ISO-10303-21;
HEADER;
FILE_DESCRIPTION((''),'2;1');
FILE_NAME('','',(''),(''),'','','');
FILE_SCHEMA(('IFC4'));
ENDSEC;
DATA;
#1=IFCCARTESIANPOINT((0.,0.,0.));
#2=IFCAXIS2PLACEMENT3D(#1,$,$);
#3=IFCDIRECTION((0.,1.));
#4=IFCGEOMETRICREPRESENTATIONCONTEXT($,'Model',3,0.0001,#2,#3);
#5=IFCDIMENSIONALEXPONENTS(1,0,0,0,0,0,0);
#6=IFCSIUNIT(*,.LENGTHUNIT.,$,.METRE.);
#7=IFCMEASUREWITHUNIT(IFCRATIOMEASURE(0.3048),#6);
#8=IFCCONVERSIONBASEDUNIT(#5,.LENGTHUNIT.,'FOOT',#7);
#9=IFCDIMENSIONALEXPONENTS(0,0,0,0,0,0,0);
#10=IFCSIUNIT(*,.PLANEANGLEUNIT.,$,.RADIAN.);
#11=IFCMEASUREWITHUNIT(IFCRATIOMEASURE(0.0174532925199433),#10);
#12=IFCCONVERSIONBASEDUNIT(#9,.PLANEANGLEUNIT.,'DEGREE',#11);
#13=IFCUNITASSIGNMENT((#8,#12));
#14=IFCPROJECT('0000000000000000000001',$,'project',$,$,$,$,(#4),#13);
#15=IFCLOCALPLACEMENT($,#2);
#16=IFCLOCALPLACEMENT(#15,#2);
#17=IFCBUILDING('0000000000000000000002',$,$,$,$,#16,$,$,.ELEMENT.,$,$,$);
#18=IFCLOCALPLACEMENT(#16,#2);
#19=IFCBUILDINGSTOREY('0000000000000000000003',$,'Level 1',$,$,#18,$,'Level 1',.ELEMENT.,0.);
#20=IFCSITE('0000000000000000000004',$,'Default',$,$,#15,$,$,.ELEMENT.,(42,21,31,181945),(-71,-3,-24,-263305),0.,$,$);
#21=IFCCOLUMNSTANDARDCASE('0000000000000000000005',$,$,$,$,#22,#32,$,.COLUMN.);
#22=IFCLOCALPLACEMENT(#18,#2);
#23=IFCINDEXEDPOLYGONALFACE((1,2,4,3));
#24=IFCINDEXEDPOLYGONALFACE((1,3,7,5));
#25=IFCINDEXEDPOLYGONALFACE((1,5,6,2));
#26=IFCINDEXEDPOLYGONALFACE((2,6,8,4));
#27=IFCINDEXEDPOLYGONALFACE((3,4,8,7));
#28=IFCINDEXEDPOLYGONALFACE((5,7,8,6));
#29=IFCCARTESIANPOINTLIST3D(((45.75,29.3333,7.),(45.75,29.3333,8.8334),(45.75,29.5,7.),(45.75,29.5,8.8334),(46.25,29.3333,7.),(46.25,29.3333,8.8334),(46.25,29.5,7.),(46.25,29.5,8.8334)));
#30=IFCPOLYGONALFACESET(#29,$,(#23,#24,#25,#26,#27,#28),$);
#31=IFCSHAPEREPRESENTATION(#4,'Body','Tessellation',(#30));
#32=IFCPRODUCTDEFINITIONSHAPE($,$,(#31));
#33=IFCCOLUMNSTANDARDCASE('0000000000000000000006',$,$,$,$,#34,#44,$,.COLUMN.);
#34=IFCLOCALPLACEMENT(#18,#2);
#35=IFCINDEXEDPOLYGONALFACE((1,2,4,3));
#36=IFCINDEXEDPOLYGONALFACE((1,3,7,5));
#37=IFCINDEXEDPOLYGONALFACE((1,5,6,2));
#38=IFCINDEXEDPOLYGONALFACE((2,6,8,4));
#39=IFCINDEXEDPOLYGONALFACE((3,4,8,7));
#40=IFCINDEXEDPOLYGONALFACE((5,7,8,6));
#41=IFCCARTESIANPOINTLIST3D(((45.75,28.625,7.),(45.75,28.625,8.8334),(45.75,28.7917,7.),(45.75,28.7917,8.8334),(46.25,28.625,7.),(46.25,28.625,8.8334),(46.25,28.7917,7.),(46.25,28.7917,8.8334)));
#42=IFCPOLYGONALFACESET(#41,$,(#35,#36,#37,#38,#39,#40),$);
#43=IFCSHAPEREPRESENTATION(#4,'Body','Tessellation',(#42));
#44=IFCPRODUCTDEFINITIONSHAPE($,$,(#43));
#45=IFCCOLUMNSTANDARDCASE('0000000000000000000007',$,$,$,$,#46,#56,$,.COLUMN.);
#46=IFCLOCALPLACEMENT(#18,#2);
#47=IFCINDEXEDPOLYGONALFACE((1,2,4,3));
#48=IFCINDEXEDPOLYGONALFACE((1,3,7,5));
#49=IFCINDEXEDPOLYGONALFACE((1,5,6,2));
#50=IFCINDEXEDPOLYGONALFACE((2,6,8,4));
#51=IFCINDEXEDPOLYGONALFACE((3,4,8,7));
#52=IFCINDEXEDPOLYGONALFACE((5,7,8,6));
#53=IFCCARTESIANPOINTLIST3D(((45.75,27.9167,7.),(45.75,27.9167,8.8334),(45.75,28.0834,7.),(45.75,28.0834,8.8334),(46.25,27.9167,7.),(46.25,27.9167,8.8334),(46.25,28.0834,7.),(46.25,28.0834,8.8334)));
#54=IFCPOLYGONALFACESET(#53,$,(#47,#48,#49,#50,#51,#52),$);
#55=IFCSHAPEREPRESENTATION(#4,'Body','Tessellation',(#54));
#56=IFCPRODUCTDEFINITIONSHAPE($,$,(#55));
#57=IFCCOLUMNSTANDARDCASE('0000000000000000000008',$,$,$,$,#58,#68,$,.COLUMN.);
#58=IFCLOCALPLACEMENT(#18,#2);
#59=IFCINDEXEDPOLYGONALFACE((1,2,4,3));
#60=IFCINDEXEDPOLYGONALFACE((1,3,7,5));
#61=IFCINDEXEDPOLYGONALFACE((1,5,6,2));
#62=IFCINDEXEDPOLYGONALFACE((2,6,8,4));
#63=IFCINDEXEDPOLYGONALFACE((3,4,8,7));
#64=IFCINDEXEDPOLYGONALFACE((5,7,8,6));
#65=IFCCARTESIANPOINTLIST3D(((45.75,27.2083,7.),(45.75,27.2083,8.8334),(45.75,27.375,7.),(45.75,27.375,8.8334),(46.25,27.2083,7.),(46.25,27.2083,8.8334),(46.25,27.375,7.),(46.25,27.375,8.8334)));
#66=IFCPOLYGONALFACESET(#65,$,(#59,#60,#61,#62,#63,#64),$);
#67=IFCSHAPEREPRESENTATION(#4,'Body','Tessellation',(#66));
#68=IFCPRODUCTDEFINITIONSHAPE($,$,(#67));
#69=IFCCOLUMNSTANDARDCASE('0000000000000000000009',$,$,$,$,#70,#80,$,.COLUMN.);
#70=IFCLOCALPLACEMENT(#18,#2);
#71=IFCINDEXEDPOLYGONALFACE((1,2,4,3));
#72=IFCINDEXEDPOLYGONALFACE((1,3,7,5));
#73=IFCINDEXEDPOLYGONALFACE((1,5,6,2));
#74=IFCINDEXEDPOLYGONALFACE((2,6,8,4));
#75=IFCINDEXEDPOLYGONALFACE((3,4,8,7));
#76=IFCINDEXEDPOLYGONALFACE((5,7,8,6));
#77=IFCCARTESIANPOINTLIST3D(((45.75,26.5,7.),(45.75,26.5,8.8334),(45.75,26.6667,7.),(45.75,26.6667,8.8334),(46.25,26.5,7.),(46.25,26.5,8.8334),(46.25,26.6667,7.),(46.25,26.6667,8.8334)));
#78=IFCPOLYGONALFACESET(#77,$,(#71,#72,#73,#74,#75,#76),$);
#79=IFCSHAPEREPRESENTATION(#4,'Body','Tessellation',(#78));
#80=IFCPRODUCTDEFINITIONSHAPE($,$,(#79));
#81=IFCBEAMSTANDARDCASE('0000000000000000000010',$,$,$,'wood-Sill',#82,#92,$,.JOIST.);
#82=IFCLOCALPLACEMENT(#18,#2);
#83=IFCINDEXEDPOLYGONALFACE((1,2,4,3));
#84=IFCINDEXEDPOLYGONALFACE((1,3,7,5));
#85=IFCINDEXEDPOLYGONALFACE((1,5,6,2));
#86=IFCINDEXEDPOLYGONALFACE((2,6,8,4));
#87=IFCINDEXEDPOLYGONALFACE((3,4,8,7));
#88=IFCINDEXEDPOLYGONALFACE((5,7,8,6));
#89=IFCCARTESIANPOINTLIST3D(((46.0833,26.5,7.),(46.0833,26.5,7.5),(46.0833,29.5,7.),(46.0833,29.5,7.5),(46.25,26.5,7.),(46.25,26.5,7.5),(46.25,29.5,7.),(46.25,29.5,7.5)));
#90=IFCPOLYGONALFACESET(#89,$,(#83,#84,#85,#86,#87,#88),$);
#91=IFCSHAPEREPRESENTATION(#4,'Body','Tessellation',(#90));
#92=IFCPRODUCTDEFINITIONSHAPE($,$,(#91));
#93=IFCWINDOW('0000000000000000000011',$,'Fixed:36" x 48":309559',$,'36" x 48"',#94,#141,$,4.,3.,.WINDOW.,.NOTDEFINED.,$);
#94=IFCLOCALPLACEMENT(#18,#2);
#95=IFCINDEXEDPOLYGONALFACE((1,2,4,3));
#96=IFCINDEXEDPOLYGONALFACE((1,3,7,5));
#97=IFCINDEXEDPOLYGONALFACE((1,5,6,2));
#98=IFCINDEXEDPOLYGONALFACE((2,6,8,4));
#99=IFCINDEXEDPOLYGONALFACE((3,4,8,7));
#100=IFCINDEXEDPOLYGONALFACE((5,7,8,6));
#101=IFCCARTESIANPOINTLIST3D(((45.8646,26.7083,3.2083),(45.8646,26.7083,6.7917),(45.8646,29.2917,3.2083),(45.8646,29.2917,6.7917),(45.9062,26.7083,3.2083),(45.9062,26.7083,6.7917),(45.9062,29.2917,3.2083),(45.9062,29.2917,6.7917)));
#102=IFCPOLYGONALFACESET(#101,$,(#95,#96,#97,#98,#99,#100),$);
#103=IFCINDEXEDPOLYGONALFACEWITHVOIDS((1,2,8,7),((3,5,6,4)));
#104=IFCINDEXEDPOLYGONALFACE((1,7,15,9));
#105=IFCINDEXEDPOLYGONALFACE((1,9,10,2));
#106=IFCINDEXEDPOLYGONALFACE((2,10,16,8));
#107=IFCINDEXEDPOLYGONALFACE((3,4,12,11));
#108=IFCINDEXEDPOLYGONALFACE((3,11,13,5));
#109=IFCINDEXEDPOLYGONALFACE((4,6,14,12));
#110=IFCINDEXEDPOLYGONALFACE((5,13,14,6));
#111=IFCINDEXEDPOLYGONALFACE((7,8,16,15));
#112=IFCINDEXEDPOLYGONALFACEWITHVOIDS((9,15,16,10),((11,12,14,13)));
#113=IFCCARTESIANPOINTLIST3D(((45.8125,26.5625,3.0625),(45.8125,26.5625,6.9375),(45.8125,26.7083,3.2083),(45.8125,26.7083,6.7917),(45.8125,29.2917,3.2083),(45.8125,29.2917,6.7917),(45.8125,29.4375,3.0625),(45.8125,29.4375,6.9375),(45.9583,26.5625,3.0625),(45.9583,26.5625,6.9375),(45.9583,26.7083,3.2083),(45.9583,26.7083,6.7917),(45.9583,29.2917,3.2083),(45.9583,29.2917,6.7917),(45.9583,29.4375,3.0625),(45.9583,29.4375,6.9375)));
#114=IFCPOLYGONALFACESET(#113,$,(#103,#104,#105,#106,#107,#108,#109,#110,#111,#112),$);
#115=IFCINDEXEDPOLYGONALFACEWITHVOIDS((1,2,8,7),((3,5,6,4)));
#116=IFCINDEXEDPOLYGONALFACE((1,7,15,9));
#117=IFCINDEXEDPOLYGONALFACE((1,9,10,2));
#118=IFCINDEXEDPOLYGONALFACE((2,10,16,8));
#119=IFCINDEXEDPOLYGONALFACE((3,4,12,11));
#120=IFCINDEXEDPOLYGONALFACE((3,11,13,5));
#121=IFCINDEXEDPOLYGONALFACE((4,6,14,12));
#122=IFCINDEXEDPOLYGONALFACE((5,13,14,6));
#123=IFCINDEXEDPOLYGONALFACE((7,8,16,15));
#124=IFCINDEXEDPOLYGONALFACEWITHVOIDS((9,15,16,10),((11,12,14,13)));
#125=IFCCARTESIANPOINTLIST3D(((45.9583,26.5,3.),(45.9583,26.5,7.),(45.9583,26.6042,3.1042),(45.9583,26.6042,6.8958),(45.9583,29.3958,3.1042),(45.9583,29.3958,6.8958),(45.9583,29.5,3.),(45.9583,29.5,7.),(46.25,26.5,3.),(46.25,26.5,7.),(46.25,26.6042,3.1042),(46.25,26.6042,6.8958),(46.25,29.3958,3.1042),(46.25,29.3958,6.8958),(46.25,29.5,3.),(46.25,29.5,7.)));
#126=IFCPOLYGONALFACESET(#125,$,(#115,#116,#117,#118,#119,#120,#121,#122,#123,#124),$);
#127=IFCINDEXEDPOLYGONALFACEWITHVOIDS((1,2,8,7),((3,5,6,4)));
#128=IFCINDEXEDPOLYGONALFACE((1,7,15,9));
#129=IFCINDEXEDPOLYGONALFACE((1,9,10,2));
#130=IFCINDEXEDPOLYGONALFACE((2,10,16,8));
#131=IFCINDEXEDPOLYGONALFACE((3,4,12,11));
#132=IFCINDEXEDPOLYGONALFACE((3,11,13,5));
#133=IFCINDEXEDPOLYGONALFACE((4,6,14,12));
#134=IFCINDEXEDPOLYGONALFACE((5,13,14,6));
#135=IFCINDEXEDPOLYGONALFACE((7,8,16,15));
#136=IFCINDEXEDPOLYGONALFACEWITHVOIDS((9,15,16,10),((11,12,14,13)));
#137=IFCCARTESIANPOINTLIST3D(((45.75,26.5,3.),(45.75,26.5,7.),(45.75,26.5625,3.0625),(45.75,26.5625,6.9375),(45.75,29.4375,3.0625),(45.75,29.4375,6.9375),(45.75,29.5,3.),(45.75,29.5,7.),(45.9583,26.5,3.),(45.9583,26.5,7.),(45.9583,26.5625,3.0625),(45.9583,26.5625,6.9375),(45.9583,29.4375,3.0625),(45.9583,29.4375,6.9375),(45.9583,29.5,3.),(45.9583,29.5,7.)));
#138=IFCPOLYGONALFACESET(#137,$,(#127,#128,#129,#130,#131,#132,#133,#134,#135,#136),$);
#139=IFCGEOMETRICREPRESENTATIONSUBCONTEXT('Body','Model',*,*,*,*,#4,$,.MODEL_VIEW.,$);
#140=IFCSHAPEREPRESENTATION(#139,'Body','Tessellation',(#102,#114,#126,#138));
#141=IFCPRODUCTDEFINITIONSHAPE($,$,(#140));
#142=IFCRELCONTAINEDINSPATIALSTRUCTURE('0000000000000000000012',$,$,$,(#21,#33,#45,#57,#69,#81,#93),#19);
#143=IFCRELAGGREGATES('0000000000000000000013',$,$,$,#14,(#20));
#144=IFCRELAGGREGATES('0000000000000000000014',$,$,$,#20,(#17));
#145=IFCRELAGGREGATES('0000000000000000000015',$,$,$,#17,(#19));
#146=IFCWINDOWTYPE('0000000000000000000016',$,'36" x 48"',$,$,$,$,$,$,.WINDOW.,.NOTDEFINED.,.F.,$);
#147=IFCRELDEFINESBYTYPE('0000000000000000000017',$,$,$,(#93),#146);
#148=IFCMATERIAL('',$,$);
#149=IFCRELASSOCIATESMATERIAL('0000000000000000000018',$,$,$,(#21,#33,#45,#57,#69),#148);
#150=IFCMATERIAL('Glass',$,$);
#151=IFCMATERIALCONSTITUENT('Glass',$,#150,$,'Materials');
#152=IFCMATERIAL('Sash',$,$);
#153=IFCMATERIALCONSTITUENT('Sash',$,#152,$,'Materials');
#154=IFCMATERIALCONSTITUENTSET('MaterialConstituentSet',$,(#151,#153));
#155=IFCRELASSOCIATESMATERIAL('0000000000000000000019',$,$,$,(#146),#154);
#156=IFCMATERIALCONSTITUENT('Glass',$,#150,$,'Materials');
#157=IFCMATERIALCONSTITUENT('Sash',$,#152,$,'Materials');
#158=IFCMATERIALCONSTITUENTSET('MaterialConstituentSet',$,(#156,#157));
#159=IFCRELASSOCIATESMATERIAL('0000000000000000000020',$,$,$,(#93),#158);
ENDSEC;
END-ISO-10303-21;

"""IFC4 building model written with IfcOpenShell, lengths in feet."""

from ifc_helpers import new_model, entity, si_unit, converted_unit, direction, frame, frame_2d, origin, origin_with_axes, place, context, subcontext, project, spatial, polyline, rectangle, outline, extrude, source, transform, mapped, material, constituent, constituent_set, type_object, type_shapes, element, save


model = new_model("IFC4")

# Units and contexts
model_context = context("Model", 3, precision=0.0001, world=origin(), true_north=direction((0.0, 1.0)))
body_context = subcontext(model_context, "Body", "Model", "MODEL_VIEW")
ifc_project = project(units=[converted_unit("LENGTHUNIT", "FOOT", entity("IfcRatioMeasure", 0.3048), si_unit("LENGTHUNIT", "METRE"), dimensions=[1, 0, 0, 0, 0, 0, 0]), converted_unit("PLANEANGLEUNIT", "DEGREE", entity("IfcRatioMeasure", 0.0174532925199433), si_unit("PLANEANGLEUNIT", "RADIAN"), dimensions=[0, 0, 0, 0, 0, 0, 0])], contexts=[model_context])

# Site, building, storey
site_placement = place(None, origin())
site = spatial("IfcSite", under=ifc_project, at=site_placement, Name="Default", CompositionType="ELEMENT", RefLatitude=(42, 21, 31, 181945), RefLongitude=(-71, -3, -24, -263305), RefElevation=0.0)
building_placement = place(site_placement, origin())
building = spatial("IfcBuilding", under=site, at=building_placement, CompositionType="ELEMENT")
storey_placement = place(building_placement, origin())
storey = spatial("IfcBuildingStorey", under=building, at=storey_placement, Name="Level 1", LongName="Level 1", CompositionType="ELEMENT", Elevation=0.0)

# Columns
placement_1 = place(storey_placement, frame((46.0, 46.25, 0.0), z_axis=(0.0, 0.0, 1.0), x_axis=(0.0, -1.0, 0.0)))
ifc_material_1 = material(Name="")
for number, where, z_axis, x_axis in (
    (1, (16.8334, 0.0, 7.0), (0.0, 0.0, 1.0), (1.0, 0.0, 0.0)),
    (2, (17.5417, 0.0, 7.0), (0.0, 0.0, 1.0), (1.0, 0.0, 0.0)),
    (3, (18.25, 0.0, 7.0), (0.0, 0.0, 1.0), (1.0, 0.0, 0.0)),
    (4, (18.9584, 0.0, 7.0), (0.0, 0.0, 1.0), (1.0, 0.0, 0.0)),
    (5, (19.6667, 0.0, 7.0), (0.0, 0.0, 1.0), (1.0, 0.0, 0.0)),
):
    element("IfcColumnStandardCase", number, at=place(placement_1, frame(where, z_axis=z_axis, x_axis=x_axis)), inside=storey, material=ifc_material_1, PredefinedType="COLUMN", context=model_context, shape_type="SweptSolid", body=[
        extrude(rectangle(XDim=0.1667, YDim=0.5), origin(), (0.0, 0.0, 1.0), 1.8334),
    ])

# Beam
for number, where, z_axis, x_axis in (
    (6, (16.75, 0.1667, 7.25), (1.0, 0.0, 0.0), (0.0, 0.0, 1.0)),
):
    element("IfcBeamStandardCase", number, at=place(placement_1, frame(where, z_axis=z_axis, x_axis=x_axis)), inside=storey, ObjectType="wood-Sill", PredefinedType="JOIST", context=model_context, shape_type="SweptSolid", body=[
        extrude(rectangle(XDim=0.5, YDim=0.1667), origin_with_axes(), (0.0, 0.0, 1.0), 3.0),
    ])

# Window
ifc_material_2 = material(Name="Glass")
ifc_constituent_1 = constituent(ifc_material_2, Name="Glass", Category="Materials")
ifc_material_3 = material(Name="Sash")
ifc_constituent_2 = constituent(ifc_material_3, Name="Sash", Category="Materials")
ifc_constituent_set_1 = constituent_set(constituents=[ifc_constituent_1, ifc_constituent_2], Name="MaterialConstituentSet")
ifc_constituent_3 = constituent(ifc_material_2, Name="Glass", Category="Materials")
ifc_constituent_4 = constituent(ifc_material_3, Name="Sash", Category="Materials")
ifc_constituent_set_2 = constituent_set(constituents=[ifc_constituent_3, ifc_constituent_4], Name="MaterialConstituentSet")
window_type = type_object("IfcWindowType", Name="36\" x 48\"", ParameterTakesPrecedence=False, PartitioningType="NOTDEFINED", PredefinedType="WINDOW", material=ifc_constituent_set_2)
shared_shape = source(origin(), body_context, "Body", "SweptSolid", [
    extrude(rectangle(XDim=0.0417, YDim=2.5833, at=frame_2d((0.0, 0.0), x_axis=(1.0, 0.0))), frame((1.5, 0.3646, 0.2083), z_axis=(0.0, 0.0, 1.0), x_axis=(0.0, 1.0, 0.0)), (0.0, 0.0, 1.0), 3.5833),
    extrude(outline(polyline([(-1.4375, -1.9375), (1.4375, -1.9375), (1.4375, 1.9375), (-1.4375, 1.9375), (-1.4375, -1.9375)]), holes=[polyline([(-1.2917, -1.7917), (-1.2917, 1.7917), (1.2917, 1.7917), (1.2917, -1.7917), (-1.2917, -1.7917)])]), frame((1.5, 0.2917, 2.0), z_axis=(0.0, 1.0, 0.0), x_axis=(1.0, 0.0, 0.0)), (0.0, 0.0, 1.0), 0.1458),
    extrude(outline(polyline([(-1.5, -2.0), (1.5, -2.0), (1.5, 2.0), (-1.5, 2.0), (-1.5, -2.0)]), holes=[polyline([(-1.3958, -1.8958), (-1.3958, 1.8958), (1.3958, 1.8958), (1.3958, -1.8958), (-1.3958, -1.8958)])]), frame((1.5, 0.0, 2.0), z_axis=(0.0, 1.0, 0.0), x_axis=(1.0, 0.0, 0.0)), (0.0, 0.0, 1.0), 0.2917),
    extrude(outline(polyline([(-2.0, -1.5), (2.0, -1.5), (2.0, 1.5), (-2.0, 1.5), (-2.0, -1.5)]), holes=[polyline([(-1.9375, -1.4375), (-1.9375, 1.4375), (1.9375, 1.4375), (1.9375, -1.4375), (-1.9375, -1.4375)])]), frame((1.5, 0.2917, 2.0), z_axis=(0.0, 1.0, 0.0), x_axis=(0.0, 0.0, -1.0)), (0.0, 0.0, 1.0), 0.2083),
])
type_shapes(window_type, [shared_shape])
placement_2 = place(placement_1, frame((19.75, 0.25, 3.0)))
window_placement = place(placement_2, frame((0.0, 0.0, 0.0), z_axis=(0.0, 0.0, 1.0), x_axis=(-1.0, 0.0, 0.0)))
element("IfcWindow", 7, at=window_placement, inside=storey, type_object=window_type, material=ifc_constituent_set_1, Name="Fixed:36\" x 48\":309559", ObjectType="36\" x 48\"", OverallHeight=4.0, OverallWidth=3.0, PartitioningType="NOTDEFINED", PredefinedType="WINDOW", context=body_context, shape_type="MappedRepresentation", body=[
    mapped(shared_shape, transform((0.0, 0.0, 0.0), scale=1.0)),
])

save(model, "model.ifc")
